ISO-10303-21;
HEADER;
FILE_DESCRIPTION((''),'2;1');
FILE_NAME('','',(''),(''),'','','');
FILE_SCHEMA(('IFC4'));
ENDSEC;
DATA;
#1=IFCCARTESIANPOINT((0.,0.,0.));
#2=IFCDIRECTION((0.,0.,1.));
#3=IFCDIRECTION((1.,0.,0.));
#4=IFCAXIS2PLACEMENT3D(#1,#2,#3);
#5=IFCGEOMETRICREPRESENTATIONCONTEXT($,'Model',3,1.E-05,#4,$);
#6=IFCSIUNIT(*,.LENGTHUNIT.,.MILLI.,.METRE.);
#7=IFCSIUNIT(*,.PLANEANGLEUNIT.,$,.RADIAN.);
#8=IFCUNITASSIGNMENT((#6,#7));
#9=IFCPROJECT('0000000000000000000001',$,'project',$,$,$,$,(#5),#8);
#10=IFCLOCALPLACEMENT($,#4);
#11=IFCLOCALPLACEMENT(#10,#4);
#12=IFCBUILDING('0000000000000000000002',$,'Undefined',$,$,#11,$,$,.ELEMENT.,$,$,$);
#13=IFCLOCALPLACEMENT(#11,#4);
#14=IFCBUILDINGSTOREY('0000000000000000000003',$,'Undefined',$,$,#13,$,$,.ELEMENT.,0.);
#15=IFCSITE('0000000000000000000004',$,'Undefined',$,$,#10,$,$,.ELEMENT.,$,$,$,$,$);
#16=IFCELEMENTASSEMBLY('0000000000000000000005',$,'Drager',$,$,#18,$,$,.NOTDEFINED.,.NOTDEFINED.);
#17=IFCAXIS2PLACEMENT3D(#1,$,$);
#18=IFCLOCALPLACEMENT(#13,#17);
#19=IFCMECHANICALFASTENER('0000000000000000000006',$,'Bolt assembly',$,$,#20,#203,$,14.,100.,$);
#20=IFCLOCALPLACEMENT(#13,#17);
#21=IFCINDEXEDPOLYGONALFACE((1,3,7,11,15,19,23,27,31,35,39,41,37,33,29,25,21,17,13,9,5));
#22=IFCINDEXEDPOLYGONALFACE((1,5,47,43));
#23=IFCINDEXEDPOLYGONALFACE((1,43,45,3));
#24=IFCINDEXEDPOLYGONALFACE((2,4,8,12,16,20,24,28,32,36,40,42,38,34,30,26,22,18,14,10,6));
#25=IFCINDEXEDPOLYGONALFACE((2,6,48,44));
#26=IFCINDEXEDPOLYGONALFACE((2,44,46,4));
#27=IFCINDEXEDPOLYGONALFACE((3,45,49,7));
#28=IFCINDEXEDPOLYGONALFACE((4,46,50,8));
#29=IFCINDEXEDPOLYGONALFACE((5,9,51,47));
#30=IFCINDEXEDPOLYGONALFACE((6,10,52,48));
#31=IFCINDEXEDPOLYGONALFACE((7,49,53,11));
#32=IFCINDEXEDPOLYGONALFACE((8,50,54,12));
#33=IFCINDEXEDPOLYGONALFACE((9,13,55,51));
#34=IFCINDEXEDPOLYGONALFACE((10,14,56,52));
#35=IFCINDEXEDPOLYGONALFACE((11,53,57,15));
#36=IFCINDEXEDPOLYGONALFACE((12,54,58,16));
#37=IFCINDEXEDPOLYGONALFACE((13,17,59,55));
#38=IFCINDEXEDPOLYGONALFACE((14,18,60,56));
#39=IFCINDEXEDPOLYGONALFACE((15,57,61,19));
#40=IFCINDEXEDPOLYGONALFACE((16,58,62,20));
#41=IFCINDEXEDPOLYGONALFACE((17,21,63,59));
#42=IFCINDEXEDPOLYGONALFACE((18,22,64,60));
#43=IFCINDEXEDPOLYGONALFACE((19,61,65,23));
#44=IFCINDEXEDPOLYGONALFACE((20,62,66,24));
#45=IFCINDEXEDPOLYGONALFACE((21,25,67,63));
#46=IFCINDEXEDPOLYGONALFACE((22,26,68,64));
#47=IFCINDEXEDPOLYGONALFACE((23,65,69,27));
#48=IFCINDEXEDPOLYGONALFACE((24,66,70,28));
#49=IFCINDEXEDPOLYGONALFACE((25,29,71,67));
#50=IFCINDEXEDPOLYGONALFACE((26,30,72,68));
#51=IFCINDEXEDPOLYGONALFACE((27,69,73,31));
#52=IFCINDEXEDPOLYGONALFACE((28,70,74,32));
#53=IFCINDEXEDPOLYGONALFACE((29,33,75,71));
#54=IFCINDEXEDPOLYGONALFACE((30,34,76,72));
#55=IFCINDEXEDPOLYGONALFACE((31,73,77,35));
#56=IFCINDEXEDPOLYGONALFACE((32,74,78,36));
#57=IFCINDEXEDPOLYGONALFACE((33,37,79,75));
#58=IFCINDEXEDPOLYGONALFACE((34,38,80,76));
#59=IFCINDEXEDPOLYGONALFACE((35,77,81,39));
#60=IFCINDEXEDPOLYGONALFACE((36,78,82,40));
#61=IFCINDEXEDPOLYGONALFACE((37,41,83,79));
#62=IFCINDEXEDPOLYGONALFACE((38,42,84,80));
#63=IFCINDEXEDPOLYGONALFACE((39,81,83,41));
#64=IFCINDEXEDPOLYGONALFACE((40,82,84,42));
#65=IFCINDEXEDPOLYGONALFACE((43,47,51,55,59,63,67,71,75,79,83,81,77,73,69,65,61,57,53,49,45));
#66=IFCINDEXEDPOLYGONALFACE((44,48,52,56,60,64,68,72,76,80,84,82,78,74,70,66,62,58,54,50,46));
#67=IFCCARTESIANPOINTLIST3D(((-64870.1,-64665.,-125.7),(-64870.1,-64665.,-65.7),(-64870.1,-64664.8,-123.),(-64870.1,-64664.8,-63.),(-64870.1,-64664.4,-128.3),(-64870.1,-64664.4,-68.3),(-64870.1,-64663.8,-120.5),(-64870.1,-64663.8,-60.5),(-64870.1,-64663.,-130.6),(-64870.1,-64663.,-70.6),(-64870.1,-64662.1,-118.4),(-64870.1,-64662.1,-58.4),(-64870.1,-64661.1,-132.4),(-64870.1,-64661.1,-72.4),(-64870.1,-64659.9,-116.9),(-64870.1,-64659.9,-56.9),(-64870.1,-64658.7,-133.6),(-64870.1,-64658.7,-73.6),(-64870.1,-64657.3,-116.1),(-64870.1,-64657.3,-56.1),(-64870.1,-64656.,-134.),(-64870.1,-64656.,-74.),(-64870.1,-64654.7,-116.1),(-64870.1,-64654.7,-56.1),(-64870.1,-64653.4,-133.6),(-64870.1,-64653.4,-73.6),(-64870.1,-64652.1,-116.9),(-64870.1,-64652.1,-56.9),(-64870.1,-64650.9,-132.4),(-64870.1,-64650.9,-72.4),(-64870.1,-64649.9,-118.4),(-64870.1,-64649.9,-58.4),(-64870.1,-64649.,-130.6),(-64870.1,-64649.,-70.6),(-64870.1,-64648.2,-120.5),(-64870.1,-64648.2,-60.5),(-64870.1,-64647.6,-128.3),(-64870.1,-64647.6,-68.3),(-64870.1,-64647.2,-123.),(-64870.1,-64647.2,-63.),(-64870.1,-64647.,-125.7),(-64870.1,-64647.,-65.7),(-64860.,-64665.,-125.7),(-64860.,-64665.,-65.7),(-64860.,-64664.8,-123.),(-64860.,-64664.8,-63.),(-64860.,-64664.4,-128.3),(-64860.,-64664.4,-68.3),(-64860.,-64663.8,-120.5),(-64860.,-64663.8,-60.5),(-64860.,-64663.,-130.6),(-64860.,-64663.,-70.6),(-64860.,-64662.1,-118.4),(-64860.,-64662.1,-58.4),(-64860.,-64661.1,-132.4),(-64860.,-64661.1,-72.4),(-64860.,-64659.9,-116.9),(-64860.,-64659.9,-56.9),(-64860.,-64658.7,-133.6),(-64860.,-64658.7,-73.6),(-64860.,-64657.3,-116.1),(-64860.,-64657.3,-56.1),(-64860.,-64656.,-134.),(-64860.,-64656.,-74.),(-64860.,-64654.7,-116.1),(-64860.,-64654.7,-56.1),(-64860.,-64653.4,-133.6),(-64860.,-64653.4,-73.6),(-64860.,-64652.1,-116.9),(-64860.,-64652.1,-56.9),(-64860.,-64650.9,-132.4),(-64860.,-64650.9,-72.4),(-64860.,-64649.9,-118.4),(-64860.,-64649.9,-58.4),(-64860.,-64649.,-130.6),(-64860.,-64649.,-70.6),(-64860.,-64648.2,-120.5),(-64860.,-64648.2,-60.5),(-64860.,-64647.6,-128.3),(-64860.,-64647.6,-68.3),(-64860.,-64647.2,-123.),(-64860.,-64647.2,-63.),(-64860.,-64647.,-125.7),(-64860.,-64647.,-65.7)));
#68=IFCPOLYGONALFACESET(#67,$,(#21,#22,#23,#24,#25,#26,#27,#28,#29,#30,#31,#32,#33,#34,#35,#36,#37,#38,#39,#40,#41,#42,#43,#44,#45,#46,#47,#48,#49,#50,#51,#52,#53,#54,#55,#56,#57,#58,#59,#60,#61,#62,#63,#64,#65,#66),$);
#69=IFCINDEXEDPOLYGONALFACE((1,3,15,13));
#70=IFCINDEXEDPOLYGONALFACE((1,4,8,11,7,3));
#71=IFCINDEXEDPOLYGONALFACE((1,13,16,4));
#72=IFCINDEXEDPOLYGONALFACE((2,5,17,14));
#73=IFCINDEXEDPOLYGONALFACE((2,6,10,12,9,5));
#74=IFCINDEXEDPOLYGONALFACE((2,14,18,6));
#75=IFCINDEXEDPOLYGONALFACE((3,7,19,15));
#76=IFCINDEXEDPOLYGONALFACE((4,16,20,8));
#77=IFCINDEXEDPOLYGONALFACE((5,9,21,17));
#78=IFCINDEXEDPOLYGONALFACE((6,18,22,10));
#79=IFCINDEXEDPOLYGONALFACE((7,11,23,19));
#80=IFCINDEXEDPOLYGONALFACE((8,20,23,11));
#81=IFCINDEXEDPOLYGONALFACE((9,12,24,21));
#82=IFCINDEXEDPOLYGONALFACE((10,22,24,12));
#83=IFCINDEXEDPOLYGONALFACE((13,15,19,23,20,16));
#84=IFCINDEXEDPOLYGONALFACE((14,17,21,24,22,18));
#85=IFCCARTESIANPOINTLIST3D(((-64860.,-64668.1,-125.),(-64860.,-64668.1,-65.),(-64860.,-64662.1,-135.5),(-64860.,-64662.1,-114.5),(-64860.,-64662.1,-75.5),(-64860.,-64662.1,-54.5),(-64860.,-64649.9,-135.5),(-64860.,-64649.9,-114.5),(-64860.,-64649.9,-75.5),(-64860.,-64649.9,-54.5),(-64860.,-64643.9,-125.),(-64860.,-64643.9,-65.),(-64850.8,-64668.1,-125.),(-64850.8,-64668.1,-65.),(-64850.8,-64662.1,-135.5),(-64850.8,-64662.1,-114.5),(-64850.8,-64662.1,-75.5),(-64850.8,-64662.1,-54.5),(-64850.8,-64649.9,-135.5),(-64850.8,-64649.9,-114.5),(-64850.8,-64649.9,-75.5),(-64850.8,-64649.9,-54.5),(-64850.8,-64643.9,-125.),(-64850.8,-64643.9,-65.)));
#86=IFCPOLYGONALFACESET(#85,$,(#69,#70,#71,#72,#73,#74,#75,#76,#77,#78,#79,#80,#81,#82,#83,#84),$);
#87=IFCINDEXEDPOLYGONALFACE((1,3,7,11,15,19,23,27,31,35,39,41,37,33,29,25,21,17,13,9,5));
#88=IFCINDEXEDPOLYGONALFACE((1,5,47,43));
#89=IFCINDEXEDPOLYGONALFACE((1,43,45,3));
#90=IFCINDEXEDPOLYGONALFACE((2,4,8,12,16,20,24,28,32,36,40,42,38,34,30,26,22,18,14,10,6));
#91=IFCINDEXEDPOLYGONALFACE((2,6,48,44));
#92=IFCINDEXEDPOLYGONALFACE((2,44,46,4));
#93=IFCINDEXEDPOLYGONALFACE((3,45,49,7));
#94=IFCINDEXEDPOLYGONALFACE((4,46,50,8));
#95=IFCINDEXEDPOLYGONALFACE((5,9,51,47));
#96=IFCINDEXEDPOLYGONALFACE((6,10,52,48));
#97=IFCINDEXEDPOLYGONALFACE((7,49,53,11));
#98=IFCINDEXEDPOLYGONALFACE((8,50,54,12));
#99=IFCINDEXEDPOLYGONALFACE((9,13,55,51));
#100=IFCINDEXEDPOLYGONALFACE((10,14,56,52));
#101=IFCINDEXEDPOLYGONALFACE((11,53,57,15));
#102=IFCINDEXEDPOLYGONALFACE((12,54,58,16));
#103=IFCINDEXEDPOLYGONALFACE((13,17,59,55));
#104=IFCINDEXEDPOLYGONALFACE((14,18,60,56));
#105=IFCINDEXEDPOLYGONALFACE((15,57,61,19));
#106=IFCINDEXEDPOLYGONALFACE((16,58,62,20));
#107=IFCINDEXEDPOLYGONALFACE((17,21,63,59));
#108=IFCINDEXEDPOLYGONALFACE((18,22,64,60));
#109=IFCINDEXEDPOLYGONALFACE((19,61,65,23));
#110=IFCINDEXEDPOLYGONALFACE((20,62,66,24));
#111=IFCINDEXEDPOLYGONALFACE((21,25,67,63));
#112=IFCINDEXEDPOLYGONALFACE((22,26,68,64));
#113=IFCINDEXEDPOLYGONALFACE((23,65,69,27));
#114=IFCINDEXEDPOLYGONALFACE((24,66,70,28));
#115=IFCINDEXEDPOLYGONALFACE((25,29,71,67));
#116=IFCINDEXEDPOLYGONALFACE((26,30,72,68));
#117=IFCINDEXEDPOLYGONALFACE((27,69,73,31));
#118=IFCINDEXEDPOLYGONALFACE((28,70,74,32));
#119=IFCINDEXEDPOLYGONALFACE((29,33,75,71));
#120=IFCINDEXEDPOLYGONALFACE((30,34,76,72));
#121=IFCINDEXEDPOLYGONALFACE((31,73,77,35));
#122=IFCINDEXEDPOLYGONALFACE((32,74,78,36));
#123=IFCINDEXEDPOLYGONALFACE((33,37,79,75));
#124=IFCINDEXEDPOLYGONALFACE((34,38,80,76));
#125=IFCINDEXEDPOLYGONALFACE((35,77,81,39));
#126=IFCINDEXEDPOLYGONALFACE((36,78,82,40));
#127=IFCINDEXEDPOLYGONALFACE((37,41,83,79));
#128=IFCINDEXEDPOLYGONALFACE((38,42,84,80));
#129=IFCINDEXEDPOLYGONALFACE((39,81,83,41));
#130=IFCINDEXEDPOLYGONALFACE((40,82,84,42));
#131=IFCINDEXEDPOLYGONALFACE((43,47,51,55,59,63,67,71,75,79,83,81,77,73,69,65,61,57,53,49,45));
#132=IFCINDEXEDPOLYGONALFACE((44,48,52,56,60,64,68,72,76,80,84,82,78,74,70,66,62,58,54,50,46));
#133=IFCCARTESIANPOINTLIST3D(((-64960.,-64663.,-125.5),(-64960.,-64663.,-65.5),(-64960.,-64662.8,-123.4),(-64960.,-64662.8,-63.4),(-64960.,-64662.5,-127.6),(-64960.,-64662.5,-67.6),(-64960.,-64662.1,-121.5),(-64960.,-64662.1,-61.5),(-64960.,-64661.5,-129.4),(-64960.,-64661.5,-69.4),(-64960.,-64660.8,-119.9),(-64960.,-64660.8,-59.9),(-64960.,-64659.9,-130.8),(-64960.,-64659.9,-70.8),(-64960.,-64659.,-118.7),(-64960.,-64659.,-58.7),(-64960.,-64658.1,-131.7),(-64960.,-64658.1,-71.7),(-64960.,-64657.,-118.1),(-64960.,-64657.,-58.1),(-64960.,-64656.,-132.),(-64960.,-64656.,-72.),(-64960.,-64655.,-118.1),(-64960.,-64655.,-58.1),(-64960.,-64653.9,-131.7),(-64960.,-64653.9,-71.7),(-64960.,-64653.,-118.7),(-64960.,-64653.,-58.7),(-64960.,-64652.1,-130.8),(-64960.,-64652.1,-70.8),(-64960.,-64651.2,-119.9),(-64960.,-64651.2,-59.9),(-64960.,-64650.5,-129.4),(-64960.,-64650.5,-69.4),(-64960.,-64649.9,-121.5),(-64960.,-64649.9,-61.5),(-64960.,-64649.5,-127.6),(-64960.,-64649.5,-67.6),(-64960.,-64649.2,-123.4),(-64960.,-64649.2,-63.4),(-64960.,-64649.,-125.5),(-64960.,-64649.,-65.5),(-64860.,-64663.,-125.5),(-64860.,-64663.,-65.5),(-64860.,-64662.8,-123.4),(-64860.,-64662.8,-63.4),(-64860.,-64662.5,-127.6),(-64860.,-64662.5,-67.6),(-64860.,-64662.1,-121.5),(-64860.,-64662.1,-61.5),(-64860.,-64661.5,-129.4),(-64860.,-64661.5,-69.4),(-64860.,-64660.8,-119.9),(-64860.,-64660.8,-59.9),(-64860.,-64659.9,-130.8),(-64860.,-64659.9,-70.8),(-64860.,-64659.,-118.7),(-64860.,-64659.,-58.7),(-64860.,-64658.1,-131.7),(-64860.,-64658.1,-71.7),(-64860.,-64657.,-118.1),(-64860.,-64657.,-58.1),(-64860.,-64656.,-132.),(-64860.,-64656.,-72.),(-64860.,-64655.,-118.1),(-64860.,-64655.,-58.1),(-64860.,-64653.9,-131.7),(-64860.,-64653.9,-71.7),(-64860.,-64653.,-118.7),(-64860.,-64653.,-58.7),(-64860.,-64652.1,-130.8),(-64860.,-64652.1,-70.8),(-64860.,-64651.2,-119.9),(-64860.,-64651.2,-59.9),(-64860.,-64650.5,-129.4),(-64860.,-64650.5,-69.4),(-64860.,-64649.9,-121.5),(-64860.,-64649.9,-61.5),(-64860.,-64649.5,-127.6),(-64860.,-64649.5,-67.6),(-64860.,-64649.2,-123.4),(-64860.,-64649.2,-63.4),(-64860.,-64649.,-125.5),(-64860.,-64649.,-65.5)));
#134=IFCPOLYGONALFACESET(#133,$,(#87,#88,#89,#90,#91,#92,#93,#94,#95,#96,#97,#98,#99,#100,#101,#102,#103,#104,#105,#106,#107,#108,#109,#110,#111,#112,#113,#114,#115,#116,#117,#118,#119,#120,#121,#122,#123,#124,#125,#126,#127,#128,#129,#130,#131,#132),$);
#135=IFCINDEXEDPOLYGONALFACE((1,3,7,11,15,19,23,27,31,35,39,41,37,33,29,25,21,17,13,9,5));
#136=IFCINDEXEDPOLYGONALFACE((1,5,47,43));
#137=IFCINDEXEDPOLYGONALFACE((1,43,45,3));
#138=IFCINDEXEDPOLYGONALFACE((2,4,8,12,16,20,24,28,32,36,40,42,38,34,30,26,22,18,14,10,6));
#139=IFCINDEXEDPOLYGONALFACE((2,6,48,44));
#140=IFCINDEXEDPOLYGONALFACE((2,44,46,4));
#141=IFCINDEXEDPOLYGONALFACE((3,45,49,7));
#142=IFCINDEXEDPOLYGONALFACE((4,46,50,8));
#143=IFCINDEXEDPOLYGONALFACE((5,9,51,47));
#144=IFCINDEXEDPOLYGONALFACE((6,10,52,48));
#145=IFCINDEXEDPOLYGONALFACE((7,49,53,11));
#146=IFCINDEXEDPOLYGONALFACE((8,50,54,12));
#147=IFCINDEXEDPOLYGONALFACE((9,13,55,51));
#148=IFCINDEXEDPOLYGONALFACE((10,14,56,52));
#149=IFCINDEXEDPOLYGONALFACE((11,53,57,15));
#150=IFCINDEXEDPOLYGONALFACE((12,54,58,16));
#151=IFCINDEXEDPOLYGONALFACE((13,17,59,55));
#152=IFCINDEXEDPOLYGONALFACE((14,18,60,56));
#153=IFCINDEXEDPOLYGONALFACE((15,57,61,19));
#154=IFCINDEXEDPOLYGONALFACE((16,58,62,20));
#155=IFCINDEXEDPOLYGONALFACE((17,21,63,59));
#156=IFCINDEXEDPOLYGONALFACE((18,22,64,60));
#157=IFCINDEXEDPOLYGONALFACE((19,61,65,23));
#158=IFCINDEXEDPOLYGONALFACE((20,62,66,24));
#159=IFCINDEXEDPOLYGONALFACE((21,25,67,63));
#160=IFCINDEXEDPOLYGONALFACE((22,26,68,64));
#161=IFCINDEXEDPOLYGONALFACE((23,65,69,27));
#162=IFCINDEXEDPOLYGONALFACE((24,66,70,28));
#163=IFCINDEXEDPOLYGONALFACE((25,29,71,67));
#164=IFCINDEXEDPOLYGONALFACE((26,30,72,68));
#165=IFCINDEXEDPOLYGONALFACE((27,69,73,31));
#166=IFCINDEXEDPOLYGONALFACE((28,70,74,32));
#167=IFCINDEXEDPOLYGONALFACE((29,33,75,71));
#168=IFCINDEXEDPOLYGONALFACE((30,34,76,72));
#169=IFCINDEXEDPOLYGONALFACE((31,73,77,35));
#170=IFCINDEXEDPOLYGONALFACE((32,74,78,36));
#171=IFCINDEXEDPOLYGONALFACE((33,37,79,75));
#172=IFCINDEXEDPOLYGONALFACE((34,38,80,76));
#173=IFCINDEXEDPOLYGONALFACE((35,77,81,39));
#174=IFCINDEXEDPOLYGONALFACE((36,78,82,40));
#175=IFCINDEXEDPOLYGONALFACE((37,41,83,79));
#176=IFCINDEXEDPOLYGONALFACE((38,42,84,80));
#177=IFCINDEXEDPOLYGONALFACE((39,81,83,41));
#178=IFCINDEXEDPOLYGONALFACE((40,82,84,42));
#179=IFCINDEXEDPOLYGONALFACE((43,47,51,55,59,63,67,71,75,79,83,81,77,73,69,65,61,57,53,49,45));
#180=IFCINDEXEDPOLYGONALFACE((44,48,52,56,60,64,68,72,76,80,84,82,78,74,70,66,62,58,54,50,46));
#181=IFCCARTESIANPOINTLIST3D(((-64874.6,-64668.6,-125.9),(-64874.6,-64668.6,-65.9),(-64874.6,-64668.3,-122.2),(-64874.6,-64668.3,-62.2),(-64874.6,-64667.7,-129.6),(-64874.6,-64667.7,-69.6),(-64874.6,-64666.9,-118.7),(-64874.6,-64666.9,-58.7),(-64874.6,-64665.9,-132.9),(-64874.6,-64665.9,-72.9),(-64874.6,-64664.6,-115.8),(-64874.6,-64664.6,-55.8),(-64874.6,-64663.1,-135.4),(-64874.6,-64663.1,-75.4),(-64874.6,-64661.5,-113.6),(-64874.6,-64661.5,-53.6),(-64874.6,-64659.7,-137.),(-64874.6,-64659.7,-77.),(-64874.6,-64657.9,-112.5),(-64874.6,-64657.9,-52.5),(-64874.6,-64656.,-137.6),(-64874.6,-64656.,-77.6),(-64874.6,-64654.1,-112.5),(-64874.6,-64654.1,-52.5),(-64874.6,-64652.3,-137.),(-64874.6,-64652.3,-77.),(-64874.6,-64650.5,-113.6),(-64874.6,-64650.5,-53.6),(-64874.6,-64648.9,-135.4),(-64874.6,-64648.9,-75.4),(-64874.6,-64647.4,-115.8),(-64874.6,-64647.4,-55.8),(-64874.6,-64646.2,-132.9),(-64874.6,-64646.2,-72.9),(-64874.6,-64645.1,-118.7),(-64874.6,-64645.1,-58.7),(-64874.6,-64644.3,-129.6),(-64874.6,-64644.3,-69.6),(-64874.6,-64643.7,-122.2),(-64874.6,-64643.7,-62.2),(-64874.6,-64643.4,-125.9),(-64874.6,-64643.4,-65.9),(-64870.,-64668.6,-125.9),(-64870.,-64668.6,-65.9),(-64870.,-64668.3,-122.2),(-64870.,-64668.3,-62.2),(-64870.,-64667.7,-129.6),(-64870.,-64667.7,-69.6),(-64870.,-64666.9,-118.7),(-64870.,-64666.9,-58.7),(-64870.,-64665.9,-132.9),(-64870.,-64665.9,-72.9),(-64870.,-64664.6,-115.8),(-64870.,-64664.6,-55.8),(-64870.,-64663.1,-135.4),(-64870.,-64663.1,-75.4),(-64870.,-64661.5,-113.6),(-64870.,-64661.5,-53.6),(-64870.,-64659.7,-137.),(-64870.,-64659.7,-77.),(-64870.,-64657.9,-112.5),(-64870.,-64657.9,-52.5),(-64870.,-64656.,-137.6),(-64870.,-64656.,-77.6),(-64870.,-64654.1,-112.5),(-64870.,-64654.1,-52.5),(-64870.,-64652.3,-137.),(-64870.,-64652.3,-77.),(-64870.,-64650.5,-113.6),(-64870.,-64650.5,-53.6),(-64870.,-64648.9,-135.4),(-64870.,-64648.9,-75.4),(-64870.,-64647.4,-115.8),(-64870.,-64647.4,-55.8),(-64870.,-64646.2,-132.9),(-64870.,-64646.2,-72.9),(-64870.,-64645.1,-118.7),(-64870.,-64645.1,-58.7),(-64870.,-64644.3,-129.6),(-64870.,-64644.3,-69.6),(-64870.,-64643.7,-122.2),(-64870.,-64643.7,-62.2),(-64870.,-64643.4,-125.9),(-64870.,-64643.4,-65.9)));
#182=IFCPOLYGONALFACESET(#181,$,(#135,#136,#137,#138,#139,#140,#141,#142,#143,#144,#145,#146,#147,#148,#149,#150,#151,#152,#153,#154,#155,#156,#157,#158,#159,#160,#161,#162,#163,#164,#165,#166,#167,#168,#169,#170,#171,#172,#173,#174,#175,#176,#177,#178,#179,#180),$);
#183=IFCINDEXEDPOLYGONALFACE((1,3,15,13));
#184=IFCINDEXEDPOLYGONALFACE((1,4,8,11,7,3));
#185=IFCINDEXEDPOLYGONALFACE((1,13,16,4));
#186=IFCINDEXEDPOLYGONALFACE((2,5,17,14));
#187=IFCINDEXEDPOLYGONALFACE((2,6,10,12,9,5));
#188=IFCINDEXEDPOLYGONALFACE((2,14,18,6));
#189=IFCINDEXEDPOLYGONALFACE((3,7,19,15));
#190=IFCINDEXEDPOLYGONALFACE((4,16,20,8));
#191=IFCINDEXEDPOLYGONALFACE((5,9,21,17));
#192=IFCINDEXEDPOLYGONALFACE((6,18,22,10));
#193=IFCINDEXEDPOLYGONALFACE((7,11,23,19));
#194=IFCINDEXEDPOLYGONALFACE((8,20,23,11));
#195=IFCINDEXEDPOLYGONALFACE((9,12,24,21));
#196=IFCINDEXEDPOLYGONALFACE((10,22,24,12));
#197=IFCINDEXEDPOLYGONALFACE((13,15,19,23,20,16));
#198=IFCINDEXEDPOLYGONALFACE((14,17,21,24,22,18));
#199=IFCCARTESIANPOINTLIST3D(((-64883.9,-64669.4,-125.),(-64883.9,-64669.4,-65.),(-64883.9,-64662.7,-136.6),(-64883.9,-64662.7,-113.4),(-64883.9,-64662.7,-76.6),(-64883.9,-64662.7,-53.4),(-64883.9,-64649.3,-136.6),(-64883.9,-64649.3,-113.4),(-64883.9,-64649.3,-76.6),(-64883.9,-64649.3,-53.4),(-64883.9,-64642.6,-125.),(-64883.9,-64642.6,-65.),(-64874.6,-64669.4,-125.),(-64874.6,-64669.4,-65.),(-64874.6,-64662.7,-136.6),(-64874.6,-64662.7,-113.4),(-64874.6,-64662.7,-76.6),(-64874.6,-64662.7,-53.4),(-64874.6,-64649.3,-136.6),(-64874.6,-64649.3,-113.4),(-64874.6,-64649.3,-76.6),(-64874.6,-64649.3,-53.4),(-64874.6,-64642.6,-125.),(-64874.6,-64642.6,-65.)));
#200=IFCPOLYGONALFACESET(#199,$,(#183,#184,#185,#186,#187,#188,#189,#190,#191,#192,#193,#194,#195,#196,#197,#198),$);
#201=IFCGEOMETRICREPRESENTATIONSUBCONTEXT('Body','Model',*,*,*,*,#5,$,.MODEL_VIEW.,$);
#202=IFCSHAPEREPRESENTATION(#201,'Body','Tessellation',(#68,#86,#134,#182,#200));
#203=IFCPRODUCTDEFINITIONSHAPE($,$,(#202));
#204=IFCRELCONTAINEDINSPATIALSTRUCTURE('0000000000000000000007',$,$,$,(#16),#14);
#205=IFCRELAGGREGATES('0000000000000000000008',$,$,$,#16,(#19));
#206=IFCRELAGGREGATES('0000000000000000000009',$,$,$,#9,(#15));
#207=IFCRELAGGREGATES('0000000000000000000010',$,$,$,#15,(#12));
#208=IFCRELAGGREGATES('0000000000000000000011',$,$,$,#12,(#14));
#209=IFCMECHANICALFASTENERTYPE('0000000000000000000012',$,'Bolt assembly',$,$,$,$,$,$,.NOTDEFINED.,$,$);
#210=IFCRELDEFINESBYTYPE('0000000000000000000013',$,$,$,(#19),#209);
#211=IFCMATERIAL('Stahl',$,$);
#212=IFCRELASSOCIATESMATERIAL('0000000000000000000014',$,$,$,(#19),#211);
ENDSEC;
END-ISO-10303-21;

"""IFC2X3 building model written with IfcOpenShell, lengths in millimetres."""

from ifc_helpers import new_model, si_unit, frame, origin_with_axes, origin_2d_with_axis, place, context, subcontext, project, spatial, polyline, circle, outline, extrude, source, transform, mapped, material, type_object, element, aggregate, save


model = new_model("IFC2X3")

# Units and contexts
model_context = context("Model", 3, precision=1e-05, world=origin_with_axes())
body_context = subcontext(model_context, "Body", "Model", "MODEL_VIEW")
ifc_project = project(units=[si_unit("LENGTHUNIT", "METRE", prefix="MILLI"), si_unit("PLANEANGLEUNIT", "RADIAN")], contexts=[model_context])

# Site, building, storey
site_placement = place(None, origin_with_axes())
site = spatial("IfcSite", under=ifc_project, at=site_placement, Name="Undefined", CompositionType="ELEMENT")
building_placement = place(site_placement, origin_with_axes())
building = spatial("IfcBuilding", under=site, at=building_placement, Name="Undefined", CompositionType="ELEMENT")
storey_placement = place(building_placement, origin_with_axes())
storey = spatial("IfcBuildingStorey", under=building, at=storey_placement, Name="Undefined", CompositionType="ELEMENT", Elevation=0.0)

# Element assembly
assembly_1_placement = place(storey_placement, origin_with_axes())
assembly_1 = element("IfcElementAssembly", 1, at=assembly_1_placement, inside=storey, Name="Drager", AssemblyPlace="NOTDEFINED", PredefinedType="NOTDEFINED")

# Shared definitions
mechanical_fastener_type = type_object("IfcMechanicalFastenerType", Name="Bolt assembly")

# Mechanical fastener
ifc_material_1 = material(Name="Stahl")
shared_shape_1 = source(origin_with_axes(), body_context, "Body", "SweptSolid", [
    extrude(circle(Radius=9.0, at=origin_2d_with_axis()), frame((0.0, 0.0, 0.0), z_axis=(0.0, 1.0, 0.0), x_axis=(1.0, 0.0, 0.0)), (0.0, 0.0, 1.0), 10.1),
    extrude(outline(polyline([(10.5, -6.1), (10.5, 6.1), (0.0, 12.1), (-10.5, 6.1), (-10.5, -6.1), (0.0, -12.1), (10.5, -6.1)])), frame((0.0, -9.2, 0.0), z_axis=(0.0, 1.0, 0.0), x_axis=(1.0, 0.0, 0.0)), (0.0, 0.0, 1.0), 9.2),
    extrude(circle(Radius=7.0, at=origin_2d_with_axis()), frame((0.0, 0.0, 0.0), z_axis=(0.0, 1.0, 0.0), x_axis=(1.0, 0.0, 0.0)), (0.0, 0.0, 1.0), 100.0),
    extrude(circle(Radius=12.6, at=origin_2d_with_axis()), frame((0.0, 10.0, 0.0), z_axis=(0.0, 1.0, 0.0), x_axis=(1.0, 0.0, 0.0)), (0.0, 0.0, 1.0), 4.6),
    extrude(outline(polyline([(11.6, -6.7), (11.6, 6.7), (0.0, 13.4), (-11.6, 6.7), (-11.6, -6.7), (0.0, -13.4), (11.6, -6.7)])), frame((0.0, 14.6, 0.0), z_axis=(0.0, 1.0, 0.0), x_axis=(1.0, 0.0, 0.0)), (0.0, 0.0, 1.0), 9.2),
])
mechanical_fastener_1_placement = place(assembly_1_placement, frame((-64860.0, -64656.0, -65.0), z_axis=(0.0, 1.0, 0.0), x_axis=(0.0, 0.0, -1.0)))
mechanical_fastener_1 = element("IfcMechanicalFastener", 2, at=mechanical_fastener_1_placement, type_object=mechanical_fastener_type, material=ifc_material_1, Name="Bolt assembly", NominalDiameter=14.0, NominalLength=100.0, context=body_context, shape_type="MappedRepresentation", body=[
    mapped(shared_shape_1, transform((0.0, 0.0, 0.0))),
    mapped(shared_shape_1, transform((60.0, 0.0, 0.0))),
])
aggregate(assembly_1, [mechanical_fastener_1])

save(model, "model.ifc")
